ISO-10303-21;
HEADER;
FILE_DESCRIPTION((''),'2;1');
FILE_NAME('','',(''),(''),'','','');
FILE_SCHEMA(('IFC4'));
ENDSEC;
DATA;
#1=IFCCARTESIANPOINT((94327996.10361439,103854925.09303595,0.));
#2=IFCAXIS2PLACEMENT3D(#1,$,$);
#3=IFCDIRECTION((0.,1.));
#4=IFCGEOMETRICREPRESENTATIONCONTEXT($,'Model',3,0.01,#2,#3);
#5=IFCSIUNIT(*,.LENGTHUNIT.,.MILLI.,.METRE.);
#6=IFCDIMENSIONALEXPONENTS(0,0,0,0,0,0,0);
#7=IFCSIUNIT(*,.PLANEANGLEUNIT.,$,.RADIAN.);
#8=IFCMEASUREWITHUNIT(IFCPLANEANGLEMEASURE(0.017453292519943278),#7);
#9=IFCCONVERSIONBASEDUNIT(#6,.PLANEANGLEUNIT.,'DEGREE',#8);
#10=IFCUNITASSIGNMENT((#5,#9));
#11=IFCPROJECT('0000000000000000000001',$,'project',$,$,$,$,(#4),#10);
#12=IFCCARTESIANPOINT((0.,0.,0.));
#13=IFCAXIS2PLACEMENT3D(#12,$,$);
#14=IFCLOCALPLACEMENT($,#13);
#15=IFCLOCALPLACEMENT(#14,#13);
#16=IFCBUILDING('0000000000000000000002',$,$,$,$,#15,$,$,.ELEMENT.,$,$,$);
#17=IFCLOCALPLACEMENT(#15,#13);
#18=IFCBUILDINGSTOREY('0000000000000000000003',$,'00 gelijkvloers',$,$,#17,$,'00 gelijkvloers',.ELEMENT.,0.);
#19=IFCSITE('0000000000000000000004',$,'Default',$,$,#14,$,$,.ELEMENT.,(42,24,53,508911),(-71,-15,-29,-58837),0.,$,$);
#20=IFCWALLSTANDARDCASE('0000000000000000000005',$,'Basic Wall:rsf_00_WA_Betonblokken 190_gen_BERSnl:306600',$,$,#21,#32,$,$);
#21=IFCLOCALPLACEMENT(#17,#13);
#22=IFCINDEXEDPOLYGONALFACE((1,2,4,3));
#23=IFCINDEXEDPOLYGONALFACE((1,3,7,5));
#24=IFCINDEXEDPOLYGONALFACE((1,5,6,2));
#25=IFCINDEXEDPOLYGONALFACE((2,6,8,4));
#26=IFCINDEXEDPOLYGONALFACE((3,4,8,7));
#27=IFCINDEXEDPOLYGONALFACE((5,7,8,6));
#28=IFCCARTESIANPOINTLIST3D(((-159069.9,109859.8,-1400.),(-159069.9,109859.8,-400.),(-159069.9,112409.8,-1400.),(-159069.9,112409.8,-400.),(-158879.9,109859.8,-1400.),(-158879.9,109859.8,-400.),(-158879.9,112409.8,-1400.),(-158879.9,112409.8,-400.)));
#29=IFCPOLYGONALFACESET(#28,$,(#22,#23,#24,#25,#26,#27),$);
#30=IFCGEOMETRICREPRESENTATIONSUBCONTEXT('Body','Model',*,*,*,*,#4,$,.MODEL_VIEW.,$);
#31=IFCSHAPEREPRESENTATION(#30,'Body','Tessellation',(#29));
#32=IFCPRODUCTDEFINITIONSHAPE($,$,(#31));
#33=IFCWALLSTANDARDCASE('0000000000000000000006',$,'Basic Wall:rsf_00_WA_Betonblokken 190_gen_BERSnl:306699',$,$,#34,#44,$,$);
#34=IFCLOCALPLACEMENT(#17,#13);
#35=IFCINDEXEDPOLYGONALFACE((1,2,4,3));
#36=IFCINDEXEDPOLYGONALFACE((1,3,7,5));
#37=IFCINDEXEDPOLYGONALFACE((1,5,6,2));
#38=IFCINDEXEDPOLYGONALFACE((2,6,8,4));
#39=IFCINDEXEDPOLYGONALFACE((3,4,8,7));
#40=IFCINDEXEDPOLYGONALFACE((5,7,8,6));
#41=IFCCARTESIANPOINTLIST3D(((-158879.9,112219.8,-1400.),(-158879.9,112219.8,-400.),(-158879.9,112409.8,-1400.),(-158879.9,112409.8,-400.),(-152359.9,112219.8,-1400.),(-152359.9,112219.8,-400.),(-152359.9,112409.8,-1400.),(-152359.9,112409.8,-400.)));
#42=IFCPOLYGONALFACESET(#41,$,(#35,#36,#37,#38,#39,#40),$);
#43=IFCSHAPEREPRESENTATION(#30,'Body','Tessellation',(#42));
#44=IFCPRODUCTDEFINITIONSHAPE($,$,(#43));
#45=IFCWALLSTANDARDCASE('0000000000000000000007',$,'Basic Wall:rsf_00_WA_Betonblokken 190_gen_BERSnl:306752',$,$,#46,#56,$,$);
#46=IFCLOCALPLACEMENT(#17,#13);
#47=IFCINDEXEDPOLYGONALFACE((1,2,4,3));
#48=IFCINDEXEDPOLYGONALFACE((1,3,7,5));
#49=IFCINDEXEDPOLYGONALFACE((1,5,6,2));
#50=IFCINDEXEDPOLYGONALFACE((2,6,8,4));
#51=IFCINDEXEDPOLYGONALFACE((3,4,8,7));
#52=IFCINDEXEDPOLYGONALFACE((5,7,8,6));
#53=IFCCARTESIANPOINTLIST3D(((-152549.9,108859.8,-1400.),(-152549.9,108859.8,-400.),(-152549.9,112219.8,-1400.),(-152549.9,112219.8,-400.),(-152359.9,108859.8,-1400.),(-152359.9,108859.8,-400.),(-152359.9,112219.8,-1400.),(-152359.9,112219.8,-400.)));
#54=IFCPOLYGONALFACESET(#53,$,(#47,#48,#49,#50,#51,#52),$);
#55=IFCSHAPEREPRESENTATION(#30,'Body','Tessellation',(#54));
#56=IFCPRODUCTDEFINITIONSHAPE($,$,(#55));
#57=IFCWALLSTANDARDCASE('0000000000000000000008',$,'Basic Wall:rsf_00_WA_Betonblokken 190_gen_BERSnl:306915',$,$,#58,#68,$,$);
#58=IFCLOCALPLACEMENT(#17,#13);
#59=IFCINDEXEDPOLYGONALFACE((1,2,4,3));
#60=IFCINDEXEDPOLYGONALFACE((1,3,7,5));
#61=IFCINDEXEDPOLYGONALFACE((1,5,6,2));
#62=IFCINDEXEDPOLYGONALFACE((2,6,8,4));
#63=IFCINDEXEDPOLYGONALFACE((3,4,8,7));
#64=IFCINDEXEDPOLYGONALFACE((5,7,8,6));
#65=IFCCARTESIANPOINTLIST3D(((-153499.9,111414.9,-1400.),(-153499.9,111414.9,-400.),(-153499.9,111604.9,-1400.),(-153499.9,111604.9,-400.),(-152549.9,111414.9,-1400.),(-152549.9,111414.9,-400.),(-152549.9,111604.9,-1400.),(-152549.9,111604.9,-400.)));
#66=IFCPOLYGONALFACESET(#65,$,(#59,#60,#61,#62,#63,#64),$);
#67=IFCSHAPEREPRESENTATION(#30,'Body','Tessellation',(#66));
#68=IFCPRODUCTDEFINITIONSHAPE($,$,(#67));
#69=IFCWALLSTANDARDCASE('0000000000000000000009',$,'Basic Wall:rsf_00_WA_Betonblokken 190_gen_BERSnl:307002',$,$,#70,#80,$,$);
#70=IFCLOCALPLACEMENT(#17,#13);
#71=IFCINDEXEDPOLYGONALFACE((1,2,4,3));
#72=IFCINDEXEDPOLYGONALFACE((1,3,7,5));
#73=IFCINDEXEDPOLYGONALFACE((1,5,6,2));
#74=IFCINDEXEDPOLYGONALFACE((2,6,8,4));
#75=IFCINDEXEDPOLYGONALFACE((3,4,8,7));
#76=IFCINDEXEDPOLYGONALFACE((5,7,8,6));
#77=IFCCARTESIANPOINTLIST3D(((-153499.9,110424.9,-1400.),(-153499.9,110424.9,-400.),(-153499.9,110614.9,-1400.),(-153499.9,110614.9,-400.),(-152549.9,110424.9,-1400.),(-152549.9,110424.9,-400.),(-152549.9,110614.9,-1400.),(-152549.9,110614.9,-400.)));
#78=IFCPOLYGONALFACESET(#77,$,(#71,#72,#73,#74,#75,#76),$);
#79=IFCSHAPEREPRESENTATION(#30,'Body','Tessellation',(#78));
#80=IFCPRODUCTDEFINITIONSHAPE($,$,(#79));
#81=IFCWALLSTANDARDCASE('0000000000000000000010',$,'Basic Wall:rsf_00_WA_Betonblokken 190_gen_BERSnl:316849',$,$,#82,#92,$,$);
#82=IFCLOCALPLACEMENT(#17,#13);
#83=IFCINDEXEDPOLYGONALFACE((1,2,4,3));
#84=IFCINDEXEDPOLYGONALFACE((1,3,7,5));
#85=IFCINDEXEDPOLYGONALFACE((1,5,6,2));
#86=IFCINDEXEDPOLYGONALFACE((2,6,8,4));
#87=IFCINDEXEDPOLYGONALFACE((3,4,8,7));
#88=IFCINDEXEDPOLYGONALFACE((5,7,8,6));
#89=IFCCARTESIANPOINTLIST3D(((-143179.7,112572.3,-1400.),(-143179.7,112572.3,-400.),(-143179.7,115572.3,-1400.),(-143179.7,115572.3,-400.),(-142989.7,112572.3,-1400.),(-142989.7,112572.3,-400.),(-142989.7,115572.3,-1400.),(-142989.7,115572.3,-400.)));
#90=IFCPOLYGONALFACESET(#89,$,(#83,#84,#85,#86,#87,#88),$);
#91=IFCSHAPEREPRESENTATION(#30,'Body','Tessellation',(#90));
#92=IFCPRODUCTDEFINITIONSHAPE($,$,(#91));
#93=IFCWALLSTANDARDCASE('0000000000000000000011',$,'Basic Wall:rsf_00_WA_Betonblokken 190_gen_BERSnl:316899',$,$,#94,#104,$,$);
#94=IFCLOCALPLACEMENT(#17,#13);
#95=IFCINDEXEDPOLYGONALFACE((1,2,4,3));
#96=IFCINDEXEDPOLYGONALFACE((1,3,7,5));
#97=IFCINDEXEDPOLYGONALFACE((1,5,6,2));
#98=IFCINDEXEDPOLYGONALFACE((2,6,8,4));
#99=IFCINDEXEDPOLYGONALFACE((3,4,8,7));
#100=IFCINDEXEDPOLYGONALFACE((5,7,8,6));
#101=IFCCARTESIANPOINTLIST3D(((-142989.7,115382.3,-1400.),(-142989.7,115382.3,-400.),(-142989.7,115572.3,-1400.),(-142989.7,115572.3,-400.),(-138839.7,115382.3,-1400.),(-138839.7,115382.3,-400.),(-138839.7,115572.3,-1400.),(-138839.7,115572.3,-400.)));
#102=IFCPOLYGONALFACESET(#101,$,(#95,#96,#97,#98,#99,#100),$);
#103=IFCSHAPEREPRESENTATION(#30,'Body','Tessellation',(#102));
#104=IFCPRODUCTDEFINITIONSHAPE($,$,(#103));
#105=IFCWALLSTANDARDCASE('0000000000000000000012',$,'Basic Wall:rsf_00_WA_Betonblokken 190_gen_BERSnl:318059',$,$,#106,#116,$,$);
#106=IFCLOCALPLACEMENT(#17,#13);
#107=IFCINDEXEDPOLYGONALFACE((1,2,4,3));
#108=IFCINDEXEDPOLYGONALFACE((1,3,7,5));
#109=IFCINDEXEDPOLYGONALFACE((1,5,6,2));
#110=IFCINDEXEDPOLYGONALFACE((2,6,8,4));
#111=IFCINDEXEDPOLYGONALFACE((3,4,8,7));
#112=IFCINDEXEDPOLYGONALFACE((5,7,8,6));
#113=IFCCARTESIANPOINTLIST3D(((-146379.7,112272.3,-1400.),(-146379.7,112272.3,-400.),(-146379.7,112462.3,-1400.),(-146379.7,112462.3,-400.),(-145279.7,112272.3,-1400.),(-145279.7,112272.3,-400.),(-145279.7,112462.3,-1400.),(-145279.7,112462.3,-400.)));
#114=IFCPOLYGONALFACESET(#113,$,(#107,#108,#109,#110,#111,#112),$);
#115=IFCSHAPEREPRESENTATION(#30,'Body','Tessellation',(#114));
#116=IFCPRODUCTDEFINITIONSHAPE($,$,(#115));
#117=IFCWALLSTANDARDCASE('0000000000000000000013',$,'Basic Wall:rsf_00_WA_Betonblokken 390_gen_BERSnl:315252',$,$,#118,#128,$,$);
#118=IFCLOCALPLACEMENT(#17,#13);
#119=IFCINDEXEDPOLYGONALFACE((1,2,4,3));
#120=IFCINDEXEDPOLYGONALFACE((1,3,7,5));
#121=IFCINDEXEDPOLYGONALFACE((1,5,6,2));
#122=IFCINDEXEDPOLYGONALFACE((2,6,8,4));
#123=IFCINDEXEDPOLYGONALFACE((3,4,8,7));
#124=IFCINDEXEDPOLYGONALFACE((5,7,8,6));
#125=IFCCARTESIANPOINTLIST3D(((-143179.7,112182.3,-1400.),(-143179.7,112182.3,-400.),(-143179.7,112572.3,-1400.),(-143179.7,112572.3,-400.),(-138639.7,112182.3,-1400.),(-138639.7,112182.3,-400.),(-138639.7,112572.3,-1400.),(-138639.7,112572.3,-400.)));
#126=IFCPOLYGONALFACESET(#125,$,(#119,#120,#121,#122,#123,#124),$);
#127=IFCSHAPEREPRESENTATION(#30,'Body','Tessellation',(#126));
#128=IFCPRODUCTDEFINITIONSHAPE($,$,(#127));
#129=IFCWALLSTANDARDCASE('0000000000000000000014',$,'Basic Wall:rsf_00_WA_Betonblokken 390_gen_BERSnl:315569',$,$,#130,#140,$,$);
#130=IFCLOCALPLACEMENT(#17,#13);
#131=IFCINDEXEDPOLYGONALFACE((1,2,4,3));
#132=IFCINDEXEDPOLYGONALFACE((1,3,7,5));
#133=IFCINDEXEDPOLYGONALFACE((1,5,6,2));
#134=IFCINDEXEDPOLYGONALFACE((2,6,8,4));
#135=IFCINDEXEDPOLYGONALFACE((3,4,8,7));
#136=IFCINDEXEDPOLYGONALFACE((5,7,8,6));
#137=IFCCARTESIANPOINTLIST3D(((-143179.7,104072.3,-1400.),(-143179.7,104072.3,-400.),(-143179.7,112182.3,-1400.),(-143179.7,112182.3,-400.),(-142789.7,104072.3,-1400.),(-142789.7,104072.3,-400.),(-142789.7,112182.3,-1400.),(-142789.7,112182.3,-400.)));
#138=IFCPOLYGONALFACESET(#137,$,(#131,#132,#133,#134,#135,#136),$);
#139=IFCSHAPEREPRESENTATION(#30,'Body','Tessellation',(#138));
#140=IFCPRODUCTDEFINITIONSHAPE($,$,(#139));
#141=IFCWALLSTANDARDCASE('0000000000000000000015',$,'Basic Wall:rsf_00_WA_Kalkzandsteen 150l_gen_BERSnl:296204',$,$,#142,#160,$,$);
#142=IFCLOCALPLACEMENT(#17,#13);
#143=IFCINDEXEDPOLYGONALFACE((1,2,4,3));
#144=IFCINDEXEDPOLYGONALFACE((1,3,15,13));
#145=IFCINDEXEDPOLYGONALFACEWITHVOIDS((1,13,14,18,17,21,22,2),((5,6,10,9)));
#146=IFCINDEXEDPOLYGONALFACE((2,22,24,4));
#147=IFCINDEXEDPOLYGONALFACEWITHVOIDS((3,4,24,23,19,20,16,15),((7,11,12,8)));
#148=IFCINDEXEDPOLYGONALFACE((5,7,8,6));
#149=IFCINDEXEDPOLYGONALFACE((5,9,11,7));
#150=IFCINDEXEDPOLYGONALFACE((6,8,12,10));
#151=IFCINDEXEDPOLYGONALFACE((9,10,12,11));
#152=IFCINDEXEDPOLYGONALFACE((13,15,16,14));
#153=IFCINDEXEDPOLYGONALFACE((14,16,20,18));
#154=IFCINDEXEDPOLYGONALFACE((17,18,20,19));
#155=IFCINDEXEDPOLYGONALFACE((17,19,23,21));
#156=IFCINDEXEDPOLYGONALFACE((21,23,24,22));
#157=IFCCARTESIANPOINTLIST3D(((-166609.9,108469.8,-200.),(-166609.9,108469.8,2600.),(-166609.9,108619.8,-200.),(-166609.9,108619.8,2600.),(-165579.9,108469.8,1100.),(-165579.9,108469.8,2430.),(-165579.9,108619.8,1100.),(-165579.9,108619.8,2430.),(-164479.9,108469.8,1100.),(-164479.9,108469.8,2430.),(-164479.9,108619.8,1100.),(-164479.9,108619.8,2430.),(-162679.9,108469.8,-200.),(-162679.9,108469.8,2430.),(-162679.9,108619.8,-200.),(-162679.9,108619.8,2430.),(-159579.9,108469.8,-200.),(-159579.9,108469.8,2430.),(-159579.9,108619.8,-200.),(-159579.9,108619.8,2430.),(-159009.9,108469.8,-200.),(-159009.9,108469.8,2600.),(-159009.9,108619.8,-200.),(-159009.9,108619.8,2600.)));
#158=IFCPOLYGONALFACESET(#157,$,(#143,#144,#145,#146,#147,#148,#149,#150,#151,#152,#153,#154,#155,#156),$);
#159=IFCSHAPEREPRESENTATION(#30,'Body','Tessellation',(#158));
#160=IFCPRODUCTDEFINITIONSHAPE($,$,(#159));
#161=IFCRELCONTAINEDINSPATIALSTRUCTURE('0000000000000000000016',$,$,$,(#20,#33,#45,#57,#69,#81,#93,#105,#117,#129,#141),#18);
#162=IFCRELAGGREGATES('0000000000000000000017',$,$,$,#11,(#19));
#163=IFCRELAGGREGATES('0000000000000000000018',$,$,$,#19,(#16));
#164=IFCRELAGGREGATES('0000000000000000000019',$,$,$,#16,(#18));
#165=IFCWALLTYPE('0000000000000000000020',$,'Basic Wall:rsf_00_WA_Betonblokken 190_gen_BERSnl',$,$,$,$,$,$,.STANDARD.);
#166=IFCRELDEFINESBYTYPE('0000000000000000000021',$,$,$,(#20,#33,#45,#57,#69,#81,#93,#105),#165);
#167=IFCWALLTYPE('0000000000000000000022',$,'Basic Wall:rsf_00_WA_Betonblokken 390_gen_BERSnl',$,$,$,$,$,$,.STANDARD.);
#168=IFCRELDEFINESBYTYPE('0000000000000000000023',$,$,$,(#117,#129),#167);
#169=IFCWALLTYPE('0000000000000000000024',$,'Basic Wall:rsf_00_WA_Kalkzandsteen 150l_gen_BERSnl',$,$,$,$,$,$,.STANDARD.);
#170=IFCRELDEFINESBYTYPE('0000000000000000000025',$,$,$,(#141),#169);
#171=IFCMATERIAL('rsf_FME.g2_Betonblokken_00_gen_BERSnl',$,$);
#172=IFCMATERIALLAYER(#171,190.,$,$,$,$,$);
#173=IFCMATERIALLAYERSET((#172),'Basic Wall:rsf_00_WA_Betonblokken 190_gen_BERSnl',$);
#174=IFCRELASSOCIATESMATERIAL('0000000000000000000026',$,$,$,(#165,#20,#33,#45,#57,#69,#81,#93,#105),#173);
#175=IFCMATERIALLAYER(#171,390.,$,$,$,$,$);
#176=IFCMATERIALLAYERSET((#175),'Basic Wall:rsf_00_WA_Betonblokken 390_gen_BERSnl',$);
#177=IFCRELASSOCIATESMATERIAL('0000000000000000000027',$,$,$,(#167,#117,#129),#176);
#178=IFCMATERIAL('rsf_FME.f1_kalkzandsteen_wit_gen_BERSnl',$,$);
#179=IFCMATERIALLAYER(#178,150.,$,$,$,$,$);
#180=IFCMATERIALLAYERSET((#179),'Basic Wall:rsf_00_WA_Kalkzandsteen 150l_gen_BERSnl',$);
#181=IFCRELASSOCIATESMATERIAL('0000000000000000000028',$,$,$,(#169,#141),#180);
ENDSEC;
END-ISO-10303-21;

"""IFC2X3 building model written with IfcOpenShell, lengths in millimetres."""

from ifc_helpers import new_model, entity, si_unit, converted_unit, direction, frame, frame_2d, origin, origin_2d_with_axis, place, context, subcontext, project, spatial, polyline, rectangle, extrude, clip, bounded_halfspace, material, layer, layer_set, layer_usage, type_object, element, save


model = new_model("IFC2X3")

# Units and contexts
model_context = context("Model", 3, precision=0.01, world=frame((94327996.10361439, 103854925.09303595, 0.0)), true_north=direction((0.0, 1.0)))
body_context = subcontext(model_context, "Body", "Model", "MODEL_VIEW")
ifc_project = project(units=[si_unit("LENGTHUNIT", "METRE", prefix="MILLI"), converted_unit("PLANEANGLEUNIT", "DEGREE", entity("IfcPlaneAngleMeasure", 0.017453292519943278), si_unit("PLANEANGLEUNIT", "RADIAN"), dimensions=[0, 0, 0, 0, 0, 0, 0])], contexts=[model_context])

# Site, building, storey
site_placement = place(None, origin())
site = spatial("IfcSite", under=ifc_project, at=site_placement, Name="Default", CompositionType="ELEMENT", RefLatitude=(42, 24, 53, 508911), RefLongitude=(-71, -15, -29, -58837), RefElevation=0.0)
building_placement = place(site_placement, origin())
building = spatial("IfcBuilding", under=site, at=building_placement, CompositionType="ELEMENT")
storey_placement = place(building_placement, origin())
storey = spatial("IfcBuildingStorey", under=building, at=storey_placement, Name="00 gelijkvloers", LongName="00 gelijkvloers", CompositionType="ELEMENT", Elevation=0.0)

# Walls
ifc_material_1 = material(Name="rsf_FME.g2_Betonblokken_00_gen_BERSnl")
ifc_layer_1 = layer(ifc_material_1, 190.0)
ifc_layer_set_1 = layer_set([ifc_layer_1], Name="Basic Wall:rsf_00_WA_Betonblokken 190_gen_BERSnl")
ifc_layer_usage_1 = layer_usage(ifc_layer_set_1, "AXIS2", "NEGATIVE", 95.0)
wall_type_1 = type_object("IfcWallType", Name="Basic Wall:rsf_00_WA_Betonblokken 190_gen_BERSnl", PredefinedType="STANDARD", material=ifc_layer_set_1)
wall_1_placement = place(storey_placement, frame((-158974.9, 109859.8, -1400.0), z_axis=(0.0, 0.0, 1.0), x_axis=(0.0, 1.0, 0.0)))
element("IfcWallStandardCase", 1, at=wall_1_placement, inside=storey, type_object=wall_type_1, material=ifc_layer_usage_1, Name="Basic Wall:rsf_00_WA_Betonblokken 190_gen_BERSnl:306600", context=body_context, shape_type="SweptSolid", body=[
    extrude(rectangle(XDim=2550.0, YDim=190.0, at=frame_2d((1275.0, 0.0), x_axis=(-1.0, 0.0))), origin(), (0.0, 0.0, 1.0), 1000.0),
])
ifc_layer_usage_2 = layer_usage(ifc_layer_set_1, "AXIS2", "NEGATIVE", 95.0)
wall_2_placement = place(storey_placement, frame((-158879.9, 112314.8, -1400.0)))
element("IfcWallStandardCase", 2, at=wall_2_placement, inside=storey, type_object=wall_type_1, material=ifc_layer_usage_2, Name="Basic Wall:rsf_00_WA_Betonblokken 190_gen_BERSnl:306699", context=body_context, shape_type="SweptSolid", body=[
    extrude(rectangle(XDim=6520.0, YDim=190.0, at=frame_2d((3260.0, 0.0), x_axis=(-1.0, 0.0))), origin(), (0.0, 0.0, 1.0), 1000.0),
])
ifc_layer_usage_3 = layer_usage(ifc_layer_set_1, "AXIS2", "NEGATIVE", 95.0)
wall_3_placement = place(storey_placement, frame((-152454.9, 112219.8, -1400.0), z_axis=(0.0, 0.0, 1.0), x_axis=(0.0, -1.0, 0.0)))
element("IfcWallStandardCase", 3, at=wall_3_placement, inside=storey, type_object=wall_type_1, material=ifc_layer_usage_3, Name="Basic Wall:rsf_00_WA_Betonblokken 190_gen_BERSnl:306752", context=body_context, shape_type="SweptSolid", body=[
    extrude(rectangle(XDim=3360.0, YDim=190.0, at=frame_2d((1680.0, 0.0), x_axis=(-1.0, 0.0))), origin(), (0.0, 0.0, 1.0), 1000.0),
])
ifc_layer_usage_4 = layer_usage(ifc_layer_set_1, "AXIS2", "NEGATIVE", 95.0)
wall_4_placement = place(storey_placement, frame((-153499.9, 111509.9, -1400.0)))
element("IfcWallStandardCase", 4, at=wall_4_placement, inside=storey, type_object=wall_type_1, material=ifc_layer_usage_4, Name="Basic Wall:rsf_00_WA_Betonblokken 190_gen_BERSnl:306915", context=body_context, shape_type="SweptSolid", body=[
    extrude(rectangle(XDim=950.0, YDim=190.0, at=frame_2d((475.0, 0.0), x_axis=(-1.0, 0.0))), origin(), (0.0, 0.0, 1.0), 1000.0),
])
ifc_layer_usage_5 = layer_usage(ifc_layer_set_1, "AXIS2", "NEGATIVE", 95.0)
wall_5_placement = place(storey_placement, frame((-153499.9, 110519.9, -1400.0)))
element("IfcWallStandardCase", 5, at=wall_5_placement, inside=storey, type_object=wall_type_1, material=ifc_layer_usage_5, Name="Basic Wall:rsf_00_WA_Betonblokken 190_gen_BERSnl:307002", context=body_context, shape_type="SweptSolid", body=[
    extrude(rectangle(XDim=950.0, YDim=190.0, at=frame_2d((475.0, 0.0), x_axis=(-1.0, 0.0))), origin(), (0.0, 0.0, 1.0), 1000.0),
])
ifc_layer_usage_6 = layer_usage(ifc_layer_set_1, "AXIS2", "NEGATIVE", 95.0)
wall_6_placement = place(storey_placement, frame((-143084.7, 112572.3, -1400.0), z_axis=(0.0, 0.0, 1.0), x_axis=(0.0, 1.0, 0.0)))
element("IfcWallStandardCase", 6, at=wall_6_placement, inside=storey, type_object=wall_type_1, material=ifc_layer_usage_6, Name="Basic Wall:rsf_00_WA_Betonblokken 190_gen_BERSnl:316849", context=body_context, shape_type="Clipping", body=[
    clip(extrude(rectangle(XDim=3000.0, YDim=190.0, at=frame_2d((1500.0, 0.0), x_axis=(-1.0, 0.0))), origin(), (0.0, 0.0, 1.0), 1000.0), bounded_halfspace(frame((0.0, -95.0, 1000.0), z_axis=(0.0, 0.0, -1.0), x_axis=(1.0, 0.0, 0.0)), True, frame((0.0, -95.0, 1000.0)), polyline([(0.0, 0.0), (2810.0, 0.0), (3000.0, 0.0), (3000.0, 190.0), (0.0, 190.0), (0.0, 0.0)]))),
])
ifc_layer_usage_7 = layer_usage(ifc_layer_set_1, "AXIS2", "NEGATIVE", 95.0)
wall_7_placement = place(storey_placement, frame((-142989.7, 115477.3, -1400.0)))
element("IfcWallStandardCase", 7, at=wall_7_placement, inside=storey, type_object=wall_type_1, material=ifc_layer_usage_7, Name="Basic Wall:rsf_00_WA_Betonblokken 190_gen_BERSnl:316899", context=body_context, shape_type="Clipping", body=[
    clip(extrude(rectangle(XDim=4150.0, YDim=190.0, at=frame_2d((2075.0, 0.0), x_axis=(-1.0, 0.0))), origin(), (0.0, 0.0, 1.0), 1000.0), bounded_halfspace(frame((0.0, -95.0, 1000.0), z_axis=(0.0, 0.0, -1.0), x_axis=(0.0, 1.0, 0.0)), True, frame((0.0, -95.0, 1000.0)), polyline([(0.0, 0.0), (3960.0, 0.0), (4150.0, 0.0), (4150.0, 190.0), (0.0, 190.0), (0.0, 0.0)]))),
])
ifc_layer_usage_8 = layer_usage(ifc_layer_set_1, "AXIS2", "NEGATIVE", 95.0)
wall_8_placement = place(storey_placement, frame((-145279.7, 112367.3, -1400.0), z_axis=(0.0, 0.0, 1.0), x_axis=(-1.0, 0.0, 0.0)))
element("IfcWallStandardCase", 8, at=wall_8_placement, inside=storey, type_object=wall_type_1, material=ifc_layer_usage_8, Name="Basic Wall:rsf_00_WA_Betonblokken 190_gen_BERSnl:318059", context=body_context, shape_type="SweptSolid", body=[
    extrude(rectangle(XDim=1100.0, YDim=190.0, at=frame_2d((550.0, 0.0), x_axis=(-1.0, 0.0))), origin(), (0.0, 0.0, 1.0), 1000.0),
])
ifc_layer_2 = layer(ifc_material_1, 390.0)
ifc_layer_set_2 = layer_set([ifc_layer_2], Name="Basic Wall:rsf_00_WA_Betonblokken 390_gen_BERSnl")
ifc_layer_usage_9 = layer_usage(ifc_layer_set_2, "AXIS2", "NEGATIVE", 195.0)
wall_type_2 = type_object("IfcWallType", Name="Basic Wall:rsf_00_WA_Betonblokken 390_gen_BERSnl", PredefinedType="STANDARD", material=ifc_layer_set_2)
wall_9_placement = place(storey_placement, frame((-143179.7, 112377.3, -1400.0)))
element("IfcWallStandardCase", 9, at=wall_9_placement, inside=storey, type_object=wall_type_2, material=ifc_layer_usage_9, Name="Basic Wall:rsf_00_WA_Betonblokken 390_gen_BERSnl:315252", context=body_context, shape_type="Clipping", body=[
    clip(extrude(rectangle(XDim=4540.0, YDim=390.0, at=frame_2d((2270.0, 0.0), x_axis=(-1.0, 0.0))), origin(), (0.0, 0.0, 1.0), 1000.0), bounded_halfspace(frame((0.0, -195.0, 1000.0), z_axis=(0.0, 0.0, -1.0), x_axis=(0.0, 1.0, 0.0)), True, frame((0.0, -195.0, 1000.0)), polyline([(0.0, 0.0), (390.0, 0.0), (4350.0, 0.0), (4540.0, 0.0), (4540.0, 390.0), (4150.0, 390.0), (190.0, 390.0), (0.0, 390.0), (0.0, 0.0)]))),
])
ifc_layer_usage_10 = layer_usage(ifc_layer_set_2, "AXIS2", "POSITIVE", -195.0)
wall_10_placement = place(storey_placement, frame((-142984.7, 112182.3, -1400.0), z_axis=(0.0, 0.0, 1.0), x_axis=(0.0, -1.0, 0.0)))
element("IfcWallStandardCase", 10, at=wall_10_placement, inside=storey, type_object=wall_type_2, material=ifc_layer_usage_10, Name="Basic Wall:rsf_00_WA_Betonblokken 390_gen_BERSnl:315569", context=body_context, shape_type="Clipping", body=[
    clip(extrude(rectangle(XDim=8110.0, YDim=390.0, at=frame_2d((4055.0, 0.0), x_axis=(-1.0, 0.0))), origin(), (0.0, 0.0, 1.0), 1000.0), bounded_halfspace(frame((0.0, -195.0, 1000.0), z_axis=(0.0, 0.0, -1.0), x_axis=(-1.0, 0.0, 0.0)), True, frame((0.0, -195.0, 1000.0)), polyline([(0.0, 0.0), (8110.0, 0.0), (8110.0, 390.0), (7720.0, 390.0), (0.0, 390.0), (0.0, 0.0)]))),
])

# Wall, openings
ifc_material_2 = material(Name="rsf_FME.f1_kalkzandsteen_wit_gen_BERSnl")
ifc_layer_3 = layer(ifc_material_2, 150.0)
ifc_layer_set_3 = layer_set([ifc_layer_3], Name="Basic Wall:rsf_00_WA_Kalkzandsteen 150l_gen_BERSnl")
ifc_layer_usage_11 = layer_usage(ifc_layer_set_3, "AXIS2", "NEGATIVE", 75.0)
wall_type_3 = type_object("IfcWallType", Name="Basic Wall:rsf_00_WA_Kalkzandsteen 150l_gen_BERSnl", PredefinedType="STANDARD", material=ifc_layer_set_3)
wall_11_placement = place(storey_placement, frame((-159009.9, 108544.8, -200.0), z_axis=(0.0, 0.0, 1.0), x_axis=(-1.0, 0.0, 0.0)))
wall_11 = element("IfcWallStandardCase", 11, at=wall_11_placement, inside=storey, type_object=wall_type_3, material=ifc_layer_usage_11, Name="Basic Wall:rsf_00_WA_Kalkzandsteen 150l_gen_BERSnl:296204", context=body_context, shape_type="Clipping", body=[
    clip(extrude(rectangle(XDim=7600.0, YDim=150.0, at=frame_2d((3800.0, 0.0), x_axis=(1.0, 0.0))), origin(), (0.0, 0.0, 1.0), 2800.0), bounded_halfspace(frame((0.0, -75.0, 2800.0), z_axis=(0.0, 0.0, -1.0), x_axis=(0.0, -1.0, 0.0)), True, frame((0.0, -75.0, 2800.0)), polyline([(0.0, 0.0), (7600.0, 0.0), (7600.0, 150.0), (7450.0, 150.0), (0.0, 150.0), (0.0, 0.0)]))),
])
opening_1_placement = place(wall_11_placement, origin())
element("IfcOpeningElement", 12, at=opening_1_placement, cuts=wall_11, ObjectType="Opening", context=body_context, shape_type="SweptSolid", body=[
    extrude(rectangle(XDim=2630.0, YDim=600.0, at=origin_2d_with_axis()), frame((370.0, -1449.0, 4315.0), z_axis=(0.0, 1.0, 0.0), x_axis=(0.0, 0.0, 1.0)), (0.0, 0.0, 1.0), 3048.0),
])
opening_2_placement = place(wall_11_placement, frame((-159009.9, 108544.8, 200.0), z_axis=(0.0, 0.0, 1.0), x_axis=(-1.0, 0.0, 0.0)))
element("IfcOpeningElement", 13, at=opening_2_placement, cuts=wall_11, ObjectType="Opening", context=body_context, shape_type="SweptSolid", body=[
    extrude(rectangle(XDim=2630.0, YDim=3100.0, at=frame_2d((0.0, 0.0), x_axis=(0.0, 1.0))), frame((-161129.9, 110143.8, 1115.0), z_axis=(0.0, -1.0, 0.0), x_axis=(1.0, 0.0, 0.0)), (0.0, 0.0, 1.0), 3048.0),
])
opening_3_placement = place(wall_11_placement, frame((-159009.9, 108544.8, 200.0), z_axis=(0.0, 0.0, 1.0), x_axis=(-1.0, 0.0, 0.0)))
element("IfcOpeningElement", 14, at=opening_3_placement, cuts=wall_11, ObjectType="Opening", context=body_context, shape_type="SweptSolid", body=[
    extrude(rectangle(XDim=1330.0, YDim=1100.0, at=frame_2d((0.0, 0.0), x_axis=(0.0, 1.0))), frame((-165029.9, 110143.8, 1765.0), z_axis=(0.0, -1.0, 0.0), x_axis=(1.0, 0.0, 0.0)), (0.0, 0.0, 1.0), 3048.0),
])

save(model, "model.ifc")
